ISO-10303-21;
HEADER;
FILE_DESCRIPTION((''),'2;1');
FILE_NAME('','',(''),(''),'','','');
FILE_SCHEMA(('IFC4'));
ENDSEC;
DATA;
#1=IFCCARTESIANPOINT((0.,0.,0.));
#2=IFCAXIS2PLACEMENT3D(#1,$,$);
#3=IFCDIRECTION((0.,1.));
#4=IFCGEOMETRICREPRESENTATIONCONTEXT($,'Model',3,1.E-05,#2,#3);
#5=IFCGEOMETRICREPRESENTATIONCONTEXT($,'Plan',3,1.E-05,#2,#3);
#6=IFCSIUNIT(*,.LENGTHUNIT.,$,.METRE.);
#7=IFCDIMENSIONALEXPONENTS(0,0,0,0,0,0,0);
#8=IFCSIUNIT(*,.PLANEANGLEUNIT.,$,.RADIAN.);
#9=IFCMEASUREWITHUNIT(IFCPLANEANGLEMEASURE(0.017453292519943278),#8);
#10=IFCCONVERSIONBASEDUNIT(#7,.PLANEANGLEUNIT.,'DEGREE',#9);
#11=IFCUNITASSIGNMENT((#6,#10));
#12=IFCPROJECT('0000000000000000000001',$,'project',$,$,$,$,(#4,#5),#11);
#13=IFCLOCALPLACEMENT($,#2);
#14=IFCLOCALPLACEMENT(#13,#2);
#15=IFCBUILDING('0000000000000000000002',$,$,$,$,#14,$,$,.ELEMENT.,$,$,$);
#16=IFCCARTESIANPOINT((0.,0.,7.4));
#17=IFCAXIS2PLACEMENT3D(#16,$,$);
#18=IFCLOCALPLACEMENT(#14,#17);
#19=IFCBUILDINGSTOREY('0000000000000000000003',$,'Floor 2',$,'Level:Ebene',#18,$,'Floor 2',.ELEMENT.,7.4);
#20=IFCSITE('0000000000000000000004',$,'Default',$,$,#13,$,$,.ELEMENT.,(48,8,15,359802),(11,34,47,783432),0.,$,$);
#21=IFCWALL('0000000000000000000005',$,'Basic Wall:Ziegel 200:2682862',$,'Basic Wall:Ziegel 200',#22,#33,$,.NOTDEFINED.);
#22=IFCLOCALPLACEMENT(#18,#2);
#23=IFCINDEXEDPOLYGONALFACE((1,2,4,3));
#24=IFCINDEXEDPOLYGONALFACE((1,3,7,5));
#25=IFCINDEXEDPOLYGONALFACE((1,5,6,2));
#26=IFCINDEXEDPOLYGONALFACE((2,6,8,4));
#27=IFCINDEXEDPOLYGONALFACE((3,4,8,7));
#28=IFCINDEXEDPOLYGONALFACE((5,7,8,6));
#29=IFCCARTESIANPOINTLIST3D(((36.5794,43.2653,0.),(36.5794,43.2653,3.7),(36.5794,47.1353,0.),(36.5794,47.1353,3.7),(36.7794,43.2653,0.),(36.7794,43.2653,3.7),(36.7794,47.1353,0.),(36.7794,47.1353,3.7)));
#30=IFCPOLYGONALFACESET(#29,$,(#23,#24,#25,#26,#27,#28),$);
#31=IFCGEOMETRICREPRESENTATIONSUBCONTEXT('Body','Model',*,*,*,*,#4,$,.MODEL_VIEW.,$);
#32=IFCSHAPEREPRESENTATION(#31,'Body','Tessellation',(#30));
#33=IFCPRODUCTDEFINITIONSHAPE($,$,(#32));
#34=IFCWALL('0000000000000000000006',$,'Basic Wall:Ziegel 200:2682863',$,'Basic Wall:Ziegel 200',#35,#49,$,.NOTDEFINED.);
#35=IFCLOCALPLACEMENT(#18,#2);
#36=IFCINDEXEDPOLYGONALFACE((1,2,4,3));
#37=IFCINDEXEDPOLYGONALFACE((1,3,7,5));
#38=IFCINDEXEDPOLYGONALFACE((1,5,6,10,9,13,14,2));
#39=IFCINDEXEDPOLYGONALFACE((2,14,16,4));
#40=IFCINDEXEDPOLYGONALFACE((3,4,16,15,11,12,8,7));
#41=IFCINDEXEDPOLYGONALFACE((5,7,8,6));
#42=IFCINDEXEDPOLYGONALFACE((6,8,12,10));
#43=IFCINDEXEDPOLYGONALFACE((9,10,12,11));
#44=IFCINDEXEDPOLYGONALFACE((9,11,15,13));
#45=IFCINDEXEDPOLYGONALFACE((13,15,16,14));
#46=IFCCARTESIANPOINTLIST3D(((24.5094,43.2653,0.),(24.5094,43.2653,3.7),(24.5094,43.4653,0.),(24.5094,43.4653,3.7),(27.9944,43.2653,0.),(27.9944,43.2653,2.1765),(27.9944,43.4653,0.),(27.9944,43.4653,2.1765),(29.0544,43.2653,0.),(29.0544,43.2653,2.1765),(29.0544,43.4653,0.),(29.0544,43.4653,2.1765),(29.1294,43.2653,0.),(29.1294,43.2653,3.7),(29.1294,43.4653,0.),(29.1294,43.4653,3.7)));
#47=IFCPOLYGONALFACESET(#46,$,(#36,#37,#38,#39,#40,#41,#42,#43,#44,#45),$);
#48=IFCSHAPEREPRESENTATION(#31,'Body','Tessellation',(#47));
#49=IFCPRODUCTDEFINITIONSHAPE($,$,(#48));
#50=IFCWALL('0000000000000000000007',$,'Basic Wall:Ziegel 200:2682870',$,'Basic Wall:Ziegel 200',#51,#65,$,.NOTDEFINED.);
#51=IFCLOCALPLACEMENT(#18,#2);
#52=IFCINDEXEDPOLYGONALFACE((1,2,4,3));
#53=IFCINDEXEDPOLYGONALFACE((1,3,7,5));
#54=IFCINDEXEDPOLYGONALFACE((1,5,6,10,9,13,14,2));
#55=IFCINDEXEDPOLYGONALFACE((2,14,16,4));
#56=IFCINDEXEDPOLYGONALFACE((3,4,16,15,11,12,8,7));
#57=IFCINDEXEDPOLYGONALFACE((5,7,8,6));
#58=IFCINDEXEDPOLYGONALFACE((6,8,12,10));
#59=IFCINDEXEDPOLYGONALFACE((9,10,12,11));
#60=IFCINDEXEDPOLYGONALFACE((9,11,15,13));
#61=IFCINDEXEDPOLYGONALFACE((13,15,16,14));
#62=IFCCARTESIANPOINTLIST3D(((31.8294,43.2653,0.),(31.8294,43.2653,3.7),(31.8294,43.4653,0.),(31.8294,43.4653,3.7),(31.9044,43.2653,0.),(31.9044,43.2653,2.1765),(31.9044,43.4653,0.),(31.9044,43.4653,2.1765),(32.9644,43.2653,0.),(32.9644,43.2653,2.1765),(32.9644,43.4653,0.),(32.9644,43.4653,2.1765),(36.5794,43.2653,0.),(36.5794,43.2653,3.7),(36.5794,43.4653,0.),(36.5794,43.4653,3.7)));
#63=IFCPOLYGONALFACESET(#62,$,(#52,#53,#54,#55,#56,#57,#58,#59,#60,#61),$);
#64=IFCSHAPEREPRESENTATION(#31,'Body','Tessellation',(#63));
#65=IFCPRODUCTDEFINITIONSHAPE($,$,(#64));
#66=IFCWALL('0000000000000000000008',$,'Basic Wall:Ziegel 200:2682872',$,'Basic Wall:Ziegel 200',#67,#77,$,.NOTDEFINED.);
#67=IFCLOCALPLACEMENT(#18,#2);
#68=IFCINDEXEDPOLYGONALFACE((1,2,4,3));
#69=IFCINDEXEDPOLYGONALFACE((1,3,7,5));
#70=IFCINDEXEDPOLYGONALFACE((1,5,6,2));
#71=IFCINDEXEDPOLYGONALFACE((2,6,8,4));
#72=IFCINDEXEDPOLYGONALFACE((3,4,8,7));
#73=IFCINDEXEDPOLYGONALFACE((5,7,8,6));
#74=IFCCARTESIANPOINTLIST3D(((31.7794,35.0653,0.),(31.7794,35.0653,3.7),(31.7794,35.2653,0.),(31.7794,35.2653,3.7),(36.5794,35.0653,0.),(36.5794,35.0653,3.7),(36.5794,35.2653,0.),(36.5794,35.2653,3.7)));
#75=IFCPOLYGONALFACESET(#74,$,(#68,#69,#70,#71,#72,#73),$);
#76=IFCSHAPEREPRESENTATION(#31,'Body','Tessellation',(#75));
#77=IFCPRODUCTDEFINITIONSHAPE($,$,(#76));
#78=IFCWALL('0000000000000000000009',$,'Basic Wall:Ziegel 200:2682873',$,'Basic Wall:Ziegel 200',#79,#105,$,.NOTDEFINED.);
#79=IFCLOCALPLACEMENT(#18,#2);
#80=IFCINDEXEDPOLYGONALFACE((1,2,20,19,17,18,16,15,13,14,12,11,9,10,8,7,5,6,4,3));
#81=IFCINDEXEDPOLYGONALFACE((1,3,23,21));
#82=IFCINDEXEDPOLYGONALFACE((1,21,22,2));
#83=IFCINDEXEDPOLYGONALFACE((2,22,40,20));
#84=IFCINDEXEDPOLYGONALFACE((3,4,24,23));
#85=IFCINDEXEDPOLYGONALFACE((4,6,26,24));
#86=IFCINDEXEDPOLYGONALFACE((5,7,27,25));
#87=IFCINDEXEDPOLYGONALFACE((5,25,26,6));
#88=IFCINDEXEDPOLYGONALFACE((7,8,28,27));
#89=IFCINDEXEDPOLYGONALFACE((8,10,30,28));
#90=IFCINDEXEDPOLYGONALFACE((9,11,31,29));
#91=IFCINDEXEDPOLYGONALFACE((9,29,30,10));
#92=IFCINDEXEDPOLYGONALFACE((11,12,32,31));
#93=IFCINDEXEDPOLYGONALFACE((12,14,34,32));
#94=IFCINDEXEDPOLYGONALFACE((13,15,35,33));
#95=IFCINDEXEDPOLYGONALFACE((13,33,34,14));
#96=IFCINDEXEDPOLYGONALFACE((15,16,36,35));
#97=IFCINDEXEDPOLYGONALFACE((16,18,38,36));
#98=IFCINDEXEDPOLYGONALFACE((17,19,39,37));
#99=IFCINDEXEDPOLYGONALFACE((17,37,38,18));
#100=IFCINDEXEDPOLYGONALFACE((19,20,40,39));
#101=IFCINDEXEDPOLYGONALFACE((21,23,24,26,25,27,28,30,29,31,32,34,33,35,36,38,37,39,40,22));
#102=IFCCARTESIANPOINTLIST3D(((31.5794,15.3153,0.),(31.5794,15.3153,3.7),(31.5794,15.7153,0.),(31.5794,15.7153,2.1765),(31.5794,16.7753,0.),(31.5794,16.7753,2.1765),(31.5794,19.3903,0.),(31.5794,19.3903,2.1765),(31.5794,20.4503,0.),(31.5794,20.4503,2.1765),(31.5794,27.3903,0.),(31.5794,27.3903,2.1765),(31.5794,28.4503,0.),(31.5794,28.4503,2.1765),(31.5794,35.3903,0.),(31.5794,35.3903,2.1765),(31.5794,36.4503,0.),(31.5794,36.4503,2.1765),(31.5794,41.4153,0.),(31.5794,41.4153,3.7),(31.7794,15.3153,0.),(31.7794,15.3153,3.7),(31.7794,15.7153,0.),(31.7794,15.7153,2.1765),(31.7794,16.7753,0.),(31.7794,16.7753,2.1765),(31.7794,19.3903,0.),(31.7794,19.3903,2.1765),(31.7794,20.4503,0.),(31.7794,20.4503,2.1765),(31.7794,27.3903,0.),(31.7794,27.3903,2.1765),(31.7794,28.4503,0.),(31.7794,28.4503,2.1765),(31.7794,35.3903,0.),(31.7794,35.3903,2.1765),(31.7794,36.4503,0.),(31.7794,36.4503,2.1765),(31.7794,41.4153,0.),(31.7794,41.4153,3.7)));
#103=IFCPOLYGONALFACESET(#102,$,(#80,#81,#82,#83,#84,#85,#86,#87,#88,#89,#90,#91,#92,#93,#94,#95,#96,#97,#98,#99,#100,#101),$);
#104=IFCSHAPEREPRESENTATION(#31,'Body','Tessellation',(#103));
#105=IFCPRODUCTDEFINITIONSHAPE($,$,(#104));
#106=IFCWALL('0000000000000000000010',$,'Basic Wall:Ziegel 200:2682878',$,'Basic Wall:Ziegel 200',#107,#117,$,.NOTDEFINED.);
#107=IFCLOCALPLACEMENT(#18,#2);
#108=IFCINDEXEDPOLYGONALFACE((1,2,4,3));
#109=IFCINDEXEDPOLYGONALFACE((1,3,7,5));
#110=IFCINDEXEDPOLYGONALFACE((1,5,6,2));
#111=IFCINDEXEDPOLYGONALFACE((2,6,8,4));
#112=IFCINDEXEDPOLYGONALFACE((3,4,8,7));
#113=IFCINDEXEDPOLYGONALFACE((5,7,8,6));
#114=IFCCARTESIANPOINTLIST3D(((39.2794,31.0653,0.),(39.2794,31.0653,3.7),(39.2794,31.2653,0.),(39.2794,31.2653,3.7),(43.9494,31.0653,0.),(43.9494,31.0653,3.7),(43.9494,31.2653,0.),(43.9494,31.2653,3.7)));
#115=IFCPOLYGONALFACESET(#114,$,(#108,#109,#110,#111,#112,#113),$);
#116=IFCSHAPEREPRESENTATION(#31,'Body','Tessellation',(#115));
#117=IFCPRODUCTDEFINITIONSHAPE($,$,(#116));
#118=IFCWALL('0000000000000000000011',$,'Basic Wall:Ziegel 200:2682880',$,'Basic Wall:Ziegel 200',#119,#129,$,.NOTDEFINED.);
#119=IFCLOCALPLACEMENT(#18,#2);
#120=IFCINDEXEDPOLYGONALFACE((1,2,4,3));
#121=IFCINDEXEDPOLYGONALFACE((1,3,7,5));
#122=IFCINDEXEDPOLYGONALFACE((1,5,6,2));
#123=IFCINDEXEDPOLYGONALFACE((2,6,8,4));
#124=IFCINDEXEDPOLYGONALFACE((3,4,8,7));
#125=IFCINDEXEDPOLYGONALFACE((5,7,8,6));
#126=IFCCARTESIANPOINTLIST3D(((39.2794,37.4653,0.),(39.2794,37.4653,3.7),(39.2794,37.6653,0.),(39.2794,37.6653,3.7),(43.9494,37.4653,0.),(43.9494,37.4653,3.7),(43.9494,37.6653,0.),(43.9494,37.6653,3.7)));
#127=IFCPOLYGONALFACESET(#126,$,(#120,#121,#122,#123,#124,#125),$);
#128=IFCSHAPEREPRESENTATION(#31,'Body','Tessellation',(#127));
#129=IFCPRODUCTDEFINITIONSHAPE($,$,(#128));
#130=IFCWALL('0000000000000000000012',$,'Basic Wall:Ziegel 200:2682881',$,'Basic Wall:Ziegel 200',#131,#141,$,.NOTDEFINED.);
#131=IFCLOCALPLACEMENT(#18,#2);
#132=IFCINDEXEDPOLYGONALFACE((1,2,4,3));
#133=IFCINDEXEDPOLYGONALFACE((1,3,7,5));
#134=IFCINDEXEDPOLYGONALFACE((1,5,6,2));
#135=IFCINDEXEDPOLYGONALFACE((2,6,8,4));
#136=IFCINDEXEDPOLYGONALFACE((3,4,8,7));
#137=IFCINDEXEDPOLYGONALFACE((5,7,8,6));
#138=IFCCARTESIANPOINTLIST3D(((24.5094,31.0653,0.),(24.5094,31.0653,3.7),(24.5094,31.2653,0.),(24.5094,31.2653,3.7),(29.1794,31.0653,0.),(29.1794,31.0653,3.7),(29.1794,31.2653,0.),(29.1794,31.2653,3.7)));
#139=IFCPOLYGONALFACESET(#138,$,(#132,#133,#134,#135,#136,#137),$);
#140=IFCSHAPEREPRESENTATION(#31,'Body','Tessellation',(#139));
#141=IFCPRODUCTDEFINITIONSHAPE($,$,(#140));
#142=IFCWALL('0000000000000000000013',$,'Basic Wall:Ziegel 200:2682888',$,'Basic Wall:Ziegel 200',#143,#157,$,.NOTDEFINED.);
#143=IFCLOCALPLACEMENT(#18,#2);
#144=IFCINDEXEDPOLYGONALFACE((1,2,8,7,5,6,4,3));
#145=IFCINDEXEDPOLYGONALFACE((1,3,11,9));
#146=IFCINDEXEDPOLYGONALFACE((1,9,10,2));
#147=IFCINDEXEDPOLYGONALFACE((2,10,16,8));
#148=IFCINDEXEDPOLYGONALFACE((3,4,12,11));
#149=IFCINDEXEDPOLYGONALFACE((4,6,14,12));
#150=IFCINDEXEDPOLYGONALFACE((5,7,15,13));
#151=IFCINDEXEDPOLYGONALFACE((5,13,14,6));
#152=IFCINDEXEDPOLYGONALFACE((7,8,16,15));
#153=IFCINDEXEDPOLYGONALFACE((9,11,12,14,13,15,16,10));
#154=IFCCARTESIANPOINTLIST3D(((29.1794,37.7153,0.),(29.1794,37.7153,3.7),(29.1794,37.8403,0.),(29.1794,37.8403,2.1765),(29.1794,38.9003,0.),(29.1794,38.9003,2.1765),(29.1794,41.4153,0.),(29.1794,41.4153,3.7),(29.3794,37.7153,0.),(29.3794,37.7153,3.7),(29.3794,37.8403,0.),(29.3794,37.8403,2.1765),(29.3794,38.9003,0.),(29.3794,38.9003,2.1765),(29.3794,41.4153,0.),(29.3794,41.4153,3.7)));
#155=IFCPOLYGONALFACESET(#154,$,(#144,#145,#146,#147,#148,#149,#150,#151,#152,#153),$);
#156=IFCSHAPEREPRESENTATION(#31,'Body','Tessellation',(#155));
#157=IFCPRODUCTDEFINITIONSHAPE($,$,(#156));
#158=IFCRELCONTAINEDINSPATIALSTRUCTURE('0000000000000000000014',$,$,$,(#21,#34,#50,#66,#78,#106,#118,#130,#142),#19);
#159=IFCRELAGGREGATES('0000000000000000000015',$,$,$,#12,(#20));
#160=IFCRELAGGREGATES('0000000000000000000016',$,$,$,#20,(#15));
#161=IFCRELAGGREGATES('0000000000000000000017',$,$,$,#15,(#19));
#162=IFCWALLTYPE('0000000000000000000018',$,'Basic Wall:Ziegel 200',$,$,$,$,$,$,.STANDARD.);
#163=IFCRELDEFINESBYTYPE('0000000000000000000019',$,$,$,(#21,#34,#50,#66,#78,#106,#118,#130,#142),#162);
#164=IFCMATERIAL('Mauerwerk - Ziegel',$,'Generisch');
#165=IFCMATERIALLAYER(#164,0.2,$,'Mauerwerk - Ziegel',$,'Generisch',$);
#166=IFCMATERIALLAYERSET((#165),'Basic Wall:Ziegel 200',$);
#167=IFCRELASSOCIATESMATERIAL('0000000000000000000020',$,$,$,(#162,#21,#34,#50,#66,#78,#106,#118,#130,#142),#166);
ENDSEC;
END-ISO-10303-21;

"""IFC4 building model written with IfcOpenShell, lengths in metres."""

from ifc_helpers import new_model, entity, si_unit, converted_unit, direction, frame, frame_2d, origin, place, context, subcontext, project, spatial, rectangle, extrude, material, layer, layer_set, layer_usage, type_object, element, save


model = new_model("IFC4")

# Units and contexts
model_context = context("Model", 3, precision=1e-05, world=origin(), true_north=direction((0.0, 1.0)))
plan_context = context("Plan", 3, precision=1e-05, world=origin(), true_north=direction((0.0, 1.0)))
body_context = subcontext(model_context, "Body", "Model", "MODEL_VIEW")
ifc_project = project(units=[si_unit("LENGTHUNIT", "METRE"), converted_unit("PLANEANGLEUNIT", "DEGREE", entity("IfcPlaneAngleMeasure", 0.017453292519943278), si_unit("PLANEANGLEUNIT", "RADIAN"), dimensions=[0, 0, 0, 0, 0, 0, 0])], contexts=[model_context, plan_context])

# Site, building, storey
site_placement = place(None, origin())
site = spatial("IfcSite", under=ifc_project, at=site_placement, Name="Default", CompositionType="ELEMENT", RefLatitude=(48, 8, 15, 359802), RefLongitude=(11, 34, 47, 783432), RefElevation=0.0)
building_placement = place(site_placement, origin())
building = spatial("IfcBuilding", under=site, at=building_placement, CompositionType="ELEMENT")
storey_placement = place(building_placement, frame((0.0, 0.0, 7.4)))
storey = spatial("IfcBuildingStorey", under=building, at=storey_placement, Name="Floor 2", ObjectType="Level:Ebene", LongName="Floor 2", CompositionType="ELEMENT", Elevation=7.4)

# Shared definitions
ifc_material_1 = material(Name="Mauerwerk - Ziegel", Category="Generisch")
ifc_layer_1 = layer(ifc_material_1, 0.2, Name="Mauerwerk - Ziegel", Category="Generisch")
ifc_layer_set_1 = layer_set([ifc_layer_1], Name="Basic Wall:Ziegel 200")
ifc_layer_usage_1 = layer_usage(ifc_layer_set_1, "AXIS2", "NEGATIVE", 0.1)
wall_type_1 = type_object("IfcWallType", Name="Basic Wall:Ziegel 200", PredefinedType="STANDARD", material=ifc_layer_set_1)

# Wall
wall_1_placement = place(storey_placement, frame((36.6794, 47.1353, 0.0), z_axis=(0.0, 0.0, 1.0), x_axis=(0.0, -1.0, 0.0)))
element("IfcWall", 1, at=wall_1_placement, inside=storey, type_object=wall_type_1, material=ifc_layer_usage_1, Name="Basic Wall:Ziegel 200:2682862", ObjectType="Basic Wall:Ziegel 200", PredefinedType="NOTDEFINED", context=body_context, shape_type="SweptSolid", body=[
    extrude(rectangle(XDim=3.87, YDim=0.2, at=frame_2d((1.935, 0.0), x_axis=(-1.0, 0.0))), origin(), (0.0, 0.0, 1.0), 3.7),
])

# Walls, openings
wall_2_placement = place(storey_placement, frame((29.1294, 43.3653, 0.0), z_axis=(0.0, 0.0, 1.0), x_axis=(-1.0, 0.0, 0.0)))
wall_2 = element("IfcWall", 2, at=wall_2_placement, inside=storey, type_object=wall_type_1, material=ifc_layer_usage_1, Name="Basic Wall:Ziegel 200:2682863", ObjectType="Basic Wall:Ziegel 200", PredefinedType="NOTDEFINED", context=body_context, shape_type="SweptSolid", body=[
    extrude(rectangle(XDim=4.62, YDim=0.2, at=frame_2d((2.31, 0.0), x_axis=(-1.0, 0.0))), origin(), (0.0, 0.0, 1.0), 3.7),
])
opening_1_placement = place(wall_2_placement, frame((0.075, -0.1, 0.0)))
element("IfcOpeningElement", 3, at=opening_1_placement, cuts=wall_2, PredefinedType="OPENING", context=body_context, shape_type="SweptSolid", body=[
    extrude(rectangle(XDim=2.1765, YDim=1.06, at=frame_2d((1.0882, 0.53), x_axis=(1.0, 0.0))), frame((0.0, 0.0, 0.0), z_axis=(0.0, 1.0, 0.0), x_axis=(0.0, 0.0, 1.0)), (0.0, 0.0, 1.0), 0.2),
])
wall_3_placement = place(storey_placement, frame((31.8294, 43.3653, 0.0)))
wall_3 = element("IfcWall", 4, at=wall_3_placement, inside=storey, type_object=wall_type_1, material=ifc_layer_usage_1, Name="Basic Wall:Ziegel 200:2682870", ObjectType="Basic Wall:Ziegel 200", PredefinedType="NOTDEFINED", context=body_context, shape_type="SweptSolid", body=[
    extrude(rectangle(XDim=4.75, YDim=0.2, at=frame_2d((2.375, 0.0), x_axis=(-1.0, 0.0))), origin(), (0.0, 0.0, 1.0), 3.7),
])
opening_2_placement = place(wall_3_placement, frame((1.135, 0.1, 0.0)))
element("IfcOpeningElement", 5, at=opening_2_placement, cuts=wall_3, PredefinedType="OPENING", context=body_context, shape_type="SweptSolid", body=[
    extrude(rectangle(XDim=2.1765, YDim=1.06, at=frame_2d((1.0882, 0.53), x_axis=(1.0, 0.0))), frame((0.0, 0.0, 0.0), z_axis=(0.0, -1.0, 0.0), x_axis=(0.0, 0.0, 1.0)), (0.0, 0.0, 1.0), 0.2),
])

# Wall
wall_4_placement = place(storey_placement, frame((36.5794, 35.1653, 0.0), z_axis=(0.0, 0.0, 1.0), x_axis=(-1.0, 0.0, 0.0)))
element("IfcWall", 6, at=wall_4_placement, inside=storey, type_object=wall_type_1, material=ifc_layer_usage_1, Name="Basic Wall:Ziegel 200:2682872", ObjectType="Basic Wall:Ziegel 200", PredefinedType="NOTDEFINED", context=body_context, shape_type="SweptSolid", body=[
    extrude(rectangle(XDim=4.8, YDim=0.2, at=frame_2d((2.4, 0.0), x_axis=(-1.0, 0.0))), origin(), (0.0, 0.0, 1.0), 3.7),
])

# Wall, openings
wall_5_placement = place(storey_placement, frame((31.6794, 41.4153, 0.0), z_axis=(0.0, 0.0, 1.0), x_axis=(0.0, -1.0, 0.0)))
wall_5 = element("IfcWall", 7, at=wall_5_placement, inside=storey, type_object=wall_type_1, material=ifc_layer_usage_1, Name="Basic Wall:Ziegel 200:2682873", ObjectType="Basic Wall:Ziegel 200", PredefinedType="NOTDEFINED", context=body_context, shape_type="SweptSolid", body=[
    extrude(rectangle(XDim=26.1, YDim=0.2, at=frame_2d((13.05, 0.0), x_axis=(1.0, 0.0))), origin(), (0.0, 0.0, 1.0), 3.7),
])
opening_3_placement = place(wall_5_placement, frame((22.025, 0.1, 0.0)))
element("IfcOpeningElement", 8, at=opening_3_placement, cuts=wall_5, PredefinedType="OPENING", context=body_context, shape_type="SweptSolid", body=[
    extrude(rectangle(XDim=2.1765, YDim=1.06, at=frame_2d((1.0882, 0.53), x_axis=(1.0, 0.0))), frame((0.0, 0.0, 0.0), z_axis=(0.0, -1.0, 0.0), x_axis=(0.0, 0.0, 1.0)), (0.0, 0.0, 1.0), 0.2),
])
opening_4_placement = place(wall_5_placement, frame((6.025, 0.1, 0.0)))
element("IfcOpeningElement", 9, at=opening_4_placement, cuts=wall_5, PredefinedType="OPENING", context=body_context, shape_type="SweptSolid", body=[
    extrude(rectangle(XDim=2.1765, YDim=1.06, at=frame_2d((1.0882, 0.53), x_axis=(1.0, 0.0))), frame((0.0, 0.0, 0.0), z_axis=(0.0, -1.0, 0.0), x_axis=(0.0, 0.0, 1.0)), (0.0, 0.0, 1.0), 0.2),
])
opening_5_placement = place(wall_5_placement, frame((14.025, 0.1, 0.0)))
element("IfcOpeningElement", 10, at=opening_5_placement, cuts=wall_5, PredefinedType="OPENING", context=body_context, shape_type="SweptSolid", body=[
    extrude(rectangle(XDim=2.1765, YDim=1.06, at=frame_2d((1.0882, 0.53), x_axis=(1.0, 0.0))), frame((0.0, 0.0, 0.0), z_axis=(0.0, -1.0, 0.0), x_axis=(0.0, 0.0, 1.0)), (0.0, 0.0, 1.0), 0.2),
])
opening_6_placement = place(wall_5_placement, frame((24.64, -0.1, 0.0)))
element("IfcOpeningElement", 11, at=opening_6_placement, cuts=wall_5, PredefinedType="OPENING", context=body_context, shape_type="SweptSolid", body=[
    extrude(rectangle(XDim=2.1765, YDim=1.06, at=frame_2d((1.0882, 0.53), x_axis=(1.0, 0.0))), frame((0.0, 0.0, 0.0), z_axis=(0.0, 1.0, 0.0), x_axis=(0.0, 0.0, 1.0)), (0.0, 0.0, 1.0), 0.2),
])

# Walls
wall_6_placement = place(storey_placement, frame((39.2794, 31.1653, 0.0)))
element("IfcWall", 12, at=wall_6_placement, inside=storey, type_object=wall_type_1, material=ifc_layer_usage_1, Name="Basic Wall:Ziegel 200:2682878", ObjectType="Basic Wall:Ziegel 200", PredefinedType="NOTDEFINED", context=body_context, shape_type="SweptSolid", body=[
    extrude(rectangle(XDim=4.67, YDim=0.2, at=frame_2d((2.335, 0.0), x_axis=(-1.0, 0.0))), origin(), (0.0, 0.0, 1.0), 3.7),
])
wall_7_placement = place(storey_placement, frame((43.9494, 37.5653, 0.0), z_axis=(0.0, 0.0, 1.0), x_axis=(-1.0, 0.0, 0.0)))
element("IfcWall", 13, at=wall_7_placement, inside=storey, type_object=wall_type_1, material=ifc_layer_usage_1, Name="Basic Wall:Ziegel 200:2682880", ObjectType="Basic Wall:Ziegel 200", PredefinedType="NOTDEFINED", context=body_context, shape_type="SweptSolid", body=[
    extrude(rectangle(XDim=4.67, YDim=0.2, at=frame_2d((2.335, 0.0), x_axis=(-1.0, 0.0))), origin(), (0.0, 0.0, 1.0), 3.7),
])
wall_8_placement = place(storey_placement, frame((29.1794, 31.1653, 0.0), z_axis=(0.0, 0.0, 1.0), x_axis=(-1.0, 0.0, 0.0)))
element("IfcWall", 14, at=wall_8_placement, inside=storey, type_object=wall_type_1, material=ifc_layer_usage_1, Name="Basic Wall:Ziegel 200:2682881", ObjectType="Basic Wall:Ziegel 200", PredefinedType="NOTDEFINED", context=body_context, shape_type="SweptSolid", body=[
    extrude(rectangle(XDim=4.67, YDim=0.2, at=frame_2d((2.335, 0.0), x_axis=(-1.0, 0.0))), origin(), (0.0, 0.0, 1.0), 3.7),
])

# Wall, opening
wall_9_placement = place(storey_placement, frame((29.2794, 41.4153, 0.0), z_axis=(0.0, 0.0, 1.0), x_axis=(0.0, -1.0, 0.0)))
wall_9 = element("IfcWall", 15, at=wall_9_placement, inside=storey, type_object=wall_type_1, material=ifc_layer_usage_1, Name="Basic Wall:Ziegel 200:2682888", ObjectType="Basic Wall:Ziegel 200", PredefinedType="NOTDEFINED", context=body_context, shape_type="SweptSolid", body=[
    extrude(rectangle(XDim=3.7, YDim=0.2, at=frame_2d((1.85, 0.0), x_axis=(1.0, 0.0))), origin(), (0.0, 0.0, 1.0), 3.7),
])
opening_7_placement = place(wall_9_placement, frame((2.515, -0.1, 0.0)))
element("IfcOpeningElement", 16, at=opening_7_placement, cuts=wall_9, PredefinedType="OPENING", context=body_context, shape_type="SweptSolid", body=[
    extrude(rectangle(XDim=2.1765, YDim=1.06, at=frame_2d((1.0882, 0.53), x_axis=(1.0, 0.0))), frame((0.0, 0.0, 0.0), z_axis=(0.0, 1.0, 0.0), x_axis=(0.0, 0.0, 1.0)), (0.0, 0.0, 1.0), 0.2),
])

save(model, "model.ifc")
